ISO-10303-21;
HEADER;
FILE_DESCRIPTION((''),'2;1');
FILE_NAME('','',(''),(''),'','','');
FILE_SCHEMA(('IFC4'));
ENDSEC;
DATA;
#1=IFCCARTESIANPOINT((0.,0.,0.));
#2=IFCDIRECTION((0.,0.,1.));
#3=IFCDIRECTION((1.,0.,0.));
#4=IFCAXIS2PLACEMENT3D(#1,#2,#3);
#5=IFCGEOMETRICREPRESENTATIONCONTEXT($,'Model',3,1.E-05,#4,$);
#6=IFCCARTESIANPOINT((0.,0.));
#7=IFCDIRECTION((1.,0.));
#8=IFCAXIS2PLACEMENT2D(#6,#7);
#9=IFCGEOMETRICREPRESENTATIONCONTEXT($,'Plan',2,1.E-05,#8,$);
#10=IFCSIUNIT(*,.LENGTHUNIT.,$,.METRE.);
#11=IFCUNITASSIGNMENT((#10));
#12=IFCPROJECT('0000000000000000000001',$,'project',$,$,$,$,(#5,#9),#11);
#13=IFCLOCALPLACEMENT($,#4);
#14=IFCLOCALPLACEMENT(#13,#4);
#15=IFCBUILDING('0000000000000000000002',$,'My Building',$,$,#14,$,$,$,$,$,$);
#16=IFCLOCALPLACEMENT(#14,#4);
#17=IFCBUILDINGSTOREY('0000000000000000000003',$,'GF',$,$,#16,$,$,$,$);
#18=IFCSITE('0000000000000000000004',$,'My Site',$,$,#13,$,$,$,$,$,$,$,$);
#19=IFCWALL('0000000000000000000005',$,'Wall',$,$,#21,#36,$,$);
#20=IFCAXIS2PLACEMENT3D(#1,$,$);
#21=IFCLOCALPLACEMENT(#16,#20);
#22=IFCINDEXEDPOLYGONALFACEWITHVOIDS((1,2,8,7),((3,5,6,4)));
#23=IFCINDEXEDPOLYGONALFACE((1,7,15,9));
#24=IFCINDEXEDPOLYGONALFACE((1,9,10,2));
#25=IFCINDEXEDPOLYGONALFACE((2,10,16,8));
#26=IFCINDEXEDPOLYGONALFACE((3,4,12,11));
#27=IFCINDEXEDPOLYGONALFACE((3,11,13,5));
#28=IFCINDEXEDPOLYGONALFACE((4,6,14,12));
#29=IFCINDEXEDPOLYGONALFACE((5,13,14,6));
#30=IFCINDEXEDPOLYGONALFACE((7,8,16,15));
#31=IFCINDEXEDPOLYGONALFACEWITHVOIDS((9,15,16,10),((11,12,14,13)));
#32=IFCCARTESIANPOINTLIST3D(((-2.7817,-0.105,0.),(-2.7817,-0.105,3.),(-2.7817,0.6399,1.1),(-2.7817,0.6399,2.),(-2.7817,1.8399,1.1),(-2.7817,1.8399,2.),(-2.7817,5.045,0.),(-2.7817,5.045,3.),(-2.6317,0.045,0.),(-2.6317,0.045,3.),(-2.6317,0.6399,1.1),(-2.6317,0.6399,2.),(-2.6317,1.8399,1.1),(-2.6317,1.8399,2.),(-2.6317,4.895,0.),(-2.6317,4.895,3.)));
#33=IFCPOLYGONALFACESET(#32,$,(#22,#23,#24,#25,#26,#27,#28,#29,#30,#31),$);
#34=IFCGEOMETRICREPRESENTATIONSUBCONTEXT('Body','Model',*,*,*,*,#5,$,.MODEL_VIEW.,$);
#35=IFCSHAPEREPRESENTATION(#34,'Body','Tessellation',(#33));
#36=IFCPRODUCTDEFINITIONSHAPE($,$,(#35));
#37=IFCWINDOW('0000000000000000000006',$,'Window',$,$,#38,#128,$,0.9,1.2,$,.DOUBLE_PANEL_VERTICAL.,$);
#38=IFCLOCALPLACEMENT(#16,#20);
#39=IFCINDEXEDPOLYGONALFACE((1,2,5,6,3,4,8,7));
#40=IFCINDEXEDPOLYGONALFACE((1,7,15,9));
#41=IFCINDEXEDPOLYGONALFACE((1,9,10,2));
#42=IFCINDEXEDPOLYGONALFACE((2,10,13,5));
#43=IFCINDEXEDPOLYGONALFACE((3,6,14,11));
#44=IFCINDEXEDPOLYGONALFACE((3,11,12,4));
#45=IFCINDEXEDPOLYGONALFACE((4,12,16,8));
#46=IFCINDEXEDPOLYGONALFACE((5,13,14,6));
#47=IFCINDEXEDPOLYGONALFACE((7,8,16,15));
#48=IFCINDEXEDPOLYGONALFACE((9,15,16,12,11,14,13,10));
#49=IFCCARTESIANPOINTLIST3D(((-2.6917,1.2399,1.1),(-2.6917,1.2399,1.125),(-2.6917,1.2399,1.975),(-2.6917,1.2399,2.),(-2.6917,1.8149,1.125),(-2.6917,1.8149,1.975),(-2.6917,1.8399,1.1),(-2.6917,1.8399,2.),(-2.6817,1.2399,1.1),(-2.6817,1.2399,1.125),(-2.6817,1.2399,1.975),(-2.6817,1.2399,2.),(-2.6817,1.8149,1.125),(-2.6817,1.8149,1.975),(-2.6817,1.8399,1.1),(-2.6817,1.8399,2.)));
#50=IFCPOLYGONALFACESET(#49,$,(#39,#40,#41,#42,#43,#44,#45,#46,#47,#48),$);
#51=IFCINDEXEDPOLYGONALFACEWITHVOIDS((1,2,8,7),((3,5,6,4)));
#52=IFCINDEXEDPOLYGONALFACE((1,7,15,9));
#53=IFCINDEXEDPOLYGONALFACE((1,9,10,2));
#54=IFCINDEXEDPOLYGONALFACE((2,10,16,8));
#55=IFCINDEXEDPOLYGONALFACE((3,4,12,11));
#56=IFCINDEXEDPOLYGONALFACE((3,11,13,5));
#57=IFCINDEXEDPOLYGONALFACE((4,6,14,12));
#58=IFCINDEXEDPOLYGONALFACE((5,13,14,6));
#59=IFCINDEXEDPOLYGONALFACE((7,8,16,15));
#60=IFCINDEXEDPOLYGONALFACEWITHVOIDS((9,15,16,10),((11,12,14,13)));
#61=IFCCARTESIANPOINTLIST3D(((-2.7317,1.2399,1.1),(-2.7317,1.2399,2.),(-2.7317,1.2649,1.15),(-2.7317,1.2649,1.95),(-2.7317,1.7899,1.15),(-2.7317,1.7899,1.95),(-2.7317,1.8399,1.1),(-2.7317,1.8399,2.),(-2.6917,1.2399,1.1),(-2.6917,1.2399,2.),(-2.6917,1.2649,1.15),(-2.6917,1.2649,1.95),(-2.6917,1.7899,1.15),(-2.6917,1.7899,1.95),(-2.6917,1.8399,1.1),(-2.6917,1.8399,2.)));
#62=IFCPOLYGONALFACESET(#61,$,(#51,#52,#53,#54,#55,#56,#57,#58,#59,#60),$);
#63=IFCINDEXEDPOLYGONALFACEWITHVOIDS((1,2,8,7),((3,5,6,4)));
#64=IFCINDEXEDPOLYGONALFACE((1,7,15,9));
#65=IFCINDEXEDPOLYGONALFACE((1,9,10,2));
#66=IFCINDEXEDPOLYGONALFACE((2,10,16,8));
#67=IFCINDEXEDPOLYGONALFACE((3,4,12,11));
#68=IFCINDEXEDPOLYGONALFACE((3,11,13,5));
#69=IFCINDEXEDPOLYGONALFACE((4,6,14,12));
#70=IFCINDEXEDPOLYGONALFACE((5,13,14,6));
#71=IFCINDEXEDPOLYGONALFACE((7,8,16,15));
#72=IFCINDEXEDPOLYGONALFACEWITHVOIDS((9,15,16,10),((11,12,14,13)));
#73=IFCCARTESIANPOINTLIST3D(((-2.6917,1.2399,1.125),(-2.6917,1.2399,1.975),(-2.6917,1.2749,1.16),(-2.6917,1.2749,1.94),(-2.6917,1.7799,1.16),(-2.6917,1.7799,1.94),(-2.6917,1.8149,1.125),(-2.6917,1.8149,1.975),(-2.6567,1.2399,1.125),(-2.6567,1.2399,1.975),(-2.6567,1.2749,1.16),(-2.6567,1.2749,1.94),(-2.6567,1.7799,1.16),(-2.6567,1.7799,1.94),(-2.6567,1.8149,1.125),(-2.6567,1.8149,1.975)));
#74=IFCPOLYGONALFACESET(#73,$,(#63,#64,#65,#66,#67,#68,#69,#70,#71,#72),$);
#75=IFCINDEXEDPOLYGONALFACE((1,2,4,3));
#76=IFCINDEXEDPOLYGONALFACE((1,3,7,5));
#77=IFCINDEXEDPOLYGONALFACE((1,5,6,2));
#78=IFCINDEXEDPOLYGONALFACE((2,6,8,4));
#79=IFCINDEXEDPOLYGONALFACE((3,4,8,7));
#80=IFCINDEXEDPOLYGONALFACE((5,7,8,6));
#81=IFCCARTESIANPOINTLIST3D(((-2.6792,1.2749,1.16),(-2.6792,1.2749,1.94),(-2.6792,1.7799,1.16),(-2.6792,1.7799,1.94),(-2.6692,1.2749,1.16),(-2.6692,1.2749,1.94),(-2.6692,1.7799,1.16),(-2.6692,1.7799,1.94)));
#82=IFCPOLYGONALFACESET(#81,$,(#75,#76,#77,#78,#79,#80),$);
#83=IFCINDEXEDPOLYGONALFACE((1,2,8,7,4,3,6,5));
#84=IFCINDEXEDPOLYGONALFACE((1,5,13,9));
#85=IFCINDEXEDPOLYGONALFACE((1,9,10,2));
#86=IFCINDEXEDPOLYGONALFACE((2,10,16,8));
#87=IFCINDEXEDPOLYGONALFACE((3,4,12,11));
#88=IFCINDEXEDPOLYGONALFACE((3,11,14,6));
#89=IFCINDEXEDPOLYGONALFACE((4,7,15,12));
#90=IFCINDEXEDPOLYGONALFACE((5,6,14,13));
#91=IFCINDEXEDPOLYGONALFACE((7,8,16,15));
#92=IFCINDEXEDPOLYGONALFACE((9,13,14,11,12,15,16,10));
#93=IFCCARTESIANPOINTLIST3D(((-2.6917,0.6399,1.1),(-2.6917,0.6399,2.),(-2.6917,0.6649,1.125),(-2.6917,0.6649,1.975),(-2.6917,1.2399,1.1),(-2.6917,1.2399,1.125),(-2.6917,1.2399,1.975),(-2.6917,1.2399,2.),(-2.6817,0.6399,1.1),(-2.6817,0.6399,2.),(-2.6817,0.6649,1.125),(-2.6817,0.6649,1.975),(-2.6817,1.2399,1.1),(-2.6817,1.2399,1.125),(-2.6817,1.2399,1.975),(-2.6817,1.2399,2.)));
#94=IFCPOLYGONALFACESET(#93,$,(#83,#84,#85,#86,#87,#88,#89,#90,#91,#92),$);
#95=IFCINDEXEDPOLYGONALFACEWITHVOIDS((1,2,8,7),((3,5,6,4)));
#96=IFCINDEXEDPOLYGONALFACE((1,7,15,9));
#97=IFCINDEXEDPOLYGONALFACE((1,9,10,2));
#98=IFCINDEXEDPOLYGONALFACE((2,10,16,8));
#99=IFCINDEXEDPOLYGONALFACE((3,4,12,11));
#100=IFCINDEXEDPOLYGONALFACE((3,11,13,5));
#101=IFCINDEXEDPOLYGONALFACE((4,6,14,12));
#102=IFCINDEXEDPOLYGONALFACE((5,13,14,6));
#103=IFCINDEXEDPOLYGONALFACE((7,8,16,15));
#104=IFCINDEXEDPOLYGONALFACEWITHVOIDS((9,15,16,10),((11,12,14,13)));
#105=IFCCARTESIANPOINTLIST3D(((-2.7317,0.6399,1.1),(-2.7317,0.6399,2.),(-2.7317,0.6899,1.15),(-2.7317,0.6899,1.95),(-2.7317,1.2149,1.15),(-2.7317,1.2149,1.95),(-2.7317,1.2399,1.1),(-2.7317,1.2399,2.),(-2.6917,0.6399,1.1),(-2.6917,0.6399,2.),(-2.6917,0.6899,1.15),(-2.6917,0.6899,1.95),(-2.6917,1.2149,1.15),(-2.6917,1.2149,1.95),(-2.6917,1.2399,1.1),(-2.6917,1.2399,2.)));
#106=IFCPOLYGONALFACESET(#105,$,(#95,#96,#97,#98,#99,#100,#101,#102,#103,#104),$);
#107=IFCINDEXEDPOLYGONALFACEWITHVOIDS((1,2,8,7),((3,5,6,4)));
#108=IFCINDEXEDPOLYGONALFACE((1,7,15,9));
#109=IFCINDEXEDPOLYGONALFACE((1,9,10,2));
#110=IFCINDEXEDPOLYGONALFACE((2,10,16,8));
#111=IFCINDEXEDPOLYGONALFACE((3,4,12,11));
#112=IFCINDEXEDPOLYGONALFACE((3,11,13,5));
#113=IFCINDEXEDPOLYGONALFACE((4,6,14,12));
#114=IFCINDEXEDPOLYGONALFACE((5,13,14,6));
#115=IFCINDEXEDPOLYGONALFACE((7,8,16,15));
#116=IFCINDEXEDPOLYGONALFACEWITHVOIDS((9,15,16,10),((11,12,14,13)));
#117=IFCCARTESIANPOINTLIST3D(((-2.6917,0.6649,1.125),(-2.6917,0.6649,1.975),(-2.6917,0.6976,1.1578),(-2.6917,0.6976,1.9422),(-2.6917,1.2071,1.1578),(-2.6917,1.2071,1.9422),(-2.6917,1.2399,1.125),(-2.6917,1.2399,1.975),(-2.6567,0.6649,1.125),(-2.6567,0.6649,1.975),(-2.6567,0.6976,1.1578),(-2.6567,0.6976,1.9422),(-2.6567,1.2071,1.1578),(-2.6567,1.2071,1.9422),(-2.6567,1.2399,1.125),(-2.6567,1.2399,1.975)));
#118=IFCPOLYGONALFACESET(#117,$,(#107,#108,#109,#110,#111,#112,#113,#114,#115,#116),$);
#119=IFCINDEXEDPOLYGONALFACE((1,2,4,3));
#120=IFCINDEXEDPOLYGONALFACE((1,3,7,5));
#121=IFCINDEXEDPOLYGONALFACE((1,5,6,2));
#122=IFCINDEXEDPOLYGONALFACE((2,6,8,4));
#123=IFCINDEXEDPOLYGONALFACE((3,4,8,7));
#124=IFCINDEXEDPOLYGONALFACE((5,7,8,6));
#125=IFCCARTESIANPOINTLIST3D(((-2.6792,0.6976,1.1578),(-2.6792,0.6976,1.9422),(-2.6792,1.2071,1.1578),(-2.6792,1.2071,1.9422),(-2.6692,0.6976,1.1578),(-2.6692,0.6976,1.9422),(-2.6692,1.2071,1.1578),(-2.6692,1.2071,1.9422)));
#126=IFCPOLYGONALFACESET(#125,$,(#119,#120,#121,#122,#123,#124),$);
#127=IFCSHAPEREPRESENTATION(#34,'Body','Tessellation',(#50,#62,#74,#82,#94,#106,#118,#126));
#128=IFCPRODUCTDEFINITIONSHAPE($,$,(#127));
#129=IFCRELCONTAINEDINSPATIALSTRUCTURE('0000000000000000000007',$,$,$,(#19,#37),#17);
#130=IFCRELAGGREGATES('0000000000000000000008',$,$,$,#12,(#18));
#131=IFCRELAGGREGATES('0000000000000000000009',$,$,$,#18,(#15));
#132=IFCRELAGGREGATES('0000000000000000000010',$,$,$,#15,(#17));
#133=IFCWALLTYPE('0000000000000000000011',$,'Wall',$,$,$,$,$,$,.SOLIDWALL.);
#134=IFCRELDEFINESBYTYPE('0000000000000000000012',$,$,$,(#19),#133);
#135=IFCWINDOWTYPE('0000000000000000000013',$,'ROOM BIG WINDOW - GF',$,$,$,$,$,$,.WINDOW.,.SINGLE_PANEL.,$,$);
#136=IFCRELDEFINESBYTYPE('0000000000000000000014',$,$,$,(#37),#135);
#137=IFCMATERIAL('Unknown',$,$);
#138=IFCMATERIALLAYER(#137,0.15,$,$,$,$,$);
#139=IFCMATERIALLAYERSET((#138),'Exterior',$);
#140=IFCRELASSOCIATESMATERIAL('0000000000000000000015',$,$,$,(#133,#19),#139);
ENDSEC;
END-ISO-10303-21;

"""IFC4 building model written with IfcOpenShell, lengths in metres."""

from ifc_helpers import new_model, entity, si_unit, frame, origin_with_axes, origin_2d_with_axis, place, context, subcontext, project, spatial, line, indexed_curve, outline, extrude, shape, source, transform, mapped, material, layer, layer_set, layer_usage, type_object, type_shapes, element, fill, save


model = new_model("IFC4")

# Units and contexts
model_context = context("Model", 3, precision=1e-05, world=origin_with_axes())
plan_context = context("Plan", 2, precision=1e-05, world=origin_2d_with_axis())
body_context_1 = subcontext(model_context, "Body", "Model", "MODEL_VIEW")
body_context_2 = subcontext(plan_context, "Body", "Plan", "PLAN_VIEW")
ifc_project = project(units=[si_unit("LENGTHUNIT", "METRE")], contexts=[model_context, plan_context])

# Site, building, storey
site_placement = place(None, origin_with_axes())
site = spatial("IfcSite", under=ifc_project, at=site_placement, Name="My Site")
building_placement = place(site_placement, origin_with_axes())
building = spatial("IfcBuilding", under=site, at=building_placement, Name="My Building")
storey_placement = place(building_placement, origin_with_axes())
storey = spatial("IfcBuildingStorey", under=building, at=storey_placement, Name="GF")

# Shared definitions
ifc_material = material(Name="Unknown")
ifc_layer_1 = layer(ifc_material, 0.15)
ifc_layer_set_1 = layer_set([ifc_layer_1], Name="Exterior")
wall_type_1 = type_object("IfcWallType", Name="Wall", PredefinedType="SOLIDWALL", material=ifc_layer_set_1)

# Wall, opening, window
ifc_layer_usage_1 = layer_usage(ifc_layer_set_1, "AXIS2", "POSITIVE", 0.0)
wall_1_placement = place(storey_placement, frame((-2.7817, 5.045, 0.0), z_axis=(0.0, 0.0, 1.0), x_axis=(0.0, -1.0, 0.0)))
wall_1 = element("IfcWall", 1, at=wall_1_placement, inside=storey, type_object=wall_type_1, material=ifc_layer_usage_1, Name="Wall", context=body_context_1, shape_type="SweptSolid", body=[
    extrude(outline(indexed_curve([(0.0, 0.0), (0.15, 0.15), (5.0, 0.15), (5.15, 0.0)], segments=[line(1, 2, 3, 4, 1)])), origin_with_axes(), (0.0, 0.0, 1.0), 3.0),
])
shared_shape_1 = source(origin_with_axes(), body_context_1, "Body", "SweptSolid", [
    extrude(outline(indexed_curve([(0.0, 0.0), (1.2, 0.0), (1.2, 0.9), (0.0, 0.9)], segments=[line(1, 2, 3, 4, 1)])), frame((0.0, -0.6, 0.0), z_axis=(0.0, -1.0, 0.0), x_axis=(1.0, 0.0, 0.0)), (0.0, 0.0, -1.0), 1.2),
])
opening_1_placement = place(wall_1_placement, frame((3.2051, 0.0, 1.1), z_axis=(0.0, 0.0, 1.0), x_axis=(1.0, 0.0, 0.0)))
opening_1 = element("IfcOpeningElement", 2, at=opening_1_placement, cuts=wall_1, PredefinedType="OPENING", context=body_context_1, shape_type="MappedRepresentation", body=[
    mapped(shared_shape_1, transform((0.0, 0.0, 0.0), x_axis=(1.0, 0.0, 0.0), y_axis=(0.0, 1.0, 0.0), z_axis=(0.0, 0.0, 1.0), scale=1.0)),
])
window_type_1 = type_object("IfcWindowType", Name="ROOM BIG WINDOW - GF", PartitioningType="SINGLE_PANEL", PredefinedType="WINDOW")
shared_shape_2 = source(origin_with_axes(), body_context_1, "Body", "SweptSolid", [
    extrude(outline(indexed_curve([(0.6, 0.0), (0.0, 0.0), (0.0, 0.9), (0.6, 0.9), (0.6, 0.875), (0.025, 0.875), (0.025, 0.025), (0.6, 0.025)], segments=[line(1, 2, 3, 4, 5, 6, 7, 8, 1)])), frame((0.0, 0.09, 0.0), z_axis=(0.0, -1.0, 0.0), x_axis=(1.0, 0.0, 0.0)), (0.0, 0.0, -1.0), 0.01),
    extrude(outline(indexed_curve([(0.0, 0.0), (0.6, 0.0), (0.6, 0.9), (0.0, 0.9)], segments=[line(1, 2, 3, 4, 1)]), holes=[indexed_curve([(0.05, 0.05), (0.575, 0.05), (0.575, 0.85), (0.05, 0.85)], segments=[line(1, 2, 3, 4, 1)])]), frame((0.0, 0.05, 0.0), z_axis=(0.0, -1.0, 0.0), x_axis=(1.0, 0.0, 0.0)), (0.0, 0.0, -1.0), 0.04),
    extrude(outline(indexed_curve([(0.0, 0.0), (0.575, 0.0), (0.575, 0.85), (0.0, 0.85)], segments=[line(1, 2, 3, 4, 1)]), holes=[indexed_curve([(0.035, 0.035), (0.54, 0.035), (0.54, 0.815), (0.035, 0.815)], segments=[line(1, 2, 3, 4, 1)])]), frame((0.025, 0.09, 0.025), z_axis=(0.0, -1.0, 0.0), x_axis=(1.0, 0.0, 0.0)), (0.0, 0.0, -1.0), 0.035),
    extrude(outline(indexed_curve([(0.035, 0.035), (0.54, 0.035), (0.54, 0.815), (0.035, 0.815)], segments=[line(1, 2, 3, 4, 1)])), frame((0.025, 0.1025, 0.025), z_axis=(0.0, -1.0, 0.0), x_axis=(1.0, 0.0, 0.0)), (0.0, 0.0, -1.0), 0.01),
    extrude(outline(indexed_curve([(0.0, 0.9), (0.6, 0.9), (0.6, 0.0), (0.0, 0.0), (0.0, 0.025), (0.575, 0.025), (0.575, 0.875), (0.0, 0.875)], segments=[line(1, 2, 3, 4, 5, 6, 7, 8, 1)])), frame((0.6, 0.09, 0.0), z_axis=(0.0, -1.0, 0.0), x_axis=(1.0, 0.0, 0.0)), (0.0, 0.0, -1.0), 0.01),
    extrude(outline(indexed_curve([(0.0, 0.0), (0.6, 0.0), (0.6, 0.9), (0.0, 0.9)], segments=[line(1, 2, 3, 4, 1)]), holes=[indexed_curve([(0.025, 0.05), (0.55, 0.05), (0.55, 0.85), (0.025, 0.85)], segments=[line(1, 2, 3, 4, 1)])]), frame((0.6, 0.05, 0.0), z_axis=(0.0, -1.0, 0.0), x_axis=(1.0, 0.0, 0.0)), (0.0, 0.0, -1.0), 0.04),
    extrude(outline(indexed_curve([(0.0, 0.0), (0.575, 0.0), (0.575, 0.85), (0.0, 0.85)], segments=[line(1, 2, 3, 4, 1)]), holes=[indexed_curve([(0.0328, 0.0328), (0.5422, 0.0328), (0.5422, 0.8172), (0.0328, 0.8172)], segments=[line(1, 2, 3, 4, 1)])]), frame((0.6, 0.09, 0.025), z_axis=(0.0, -1.0, 0.0), x_axis=(1.0, 0.0, 0.0)), (0.0, 0.0, -1.0), 0.035),
    extrude(outline(indexed_curve([(0.0328, 0.0328), (0.5422, 0.0328), (0.5422, 0.8172), (0.0328, 0.8172)], segments=[line(1, 2, 3, 4, 1)])), frame((0.6, 0.1025, 0.025), z_axis=(0.0, -1.0, 0.0), x_axis=(1.0, 0.0, 0.0)), (0.0, 0.0, -1.0), 0.01),
])
shared_shape_3 = source(origin_with_axes(), body_context_2, "Body", "Curve2D", [
    entity("IfcIndexedPolyCurve", entity("IfcCartesianPointList2D", [[0.05, 0.05], [0.575, 0.05]])),
    entity("IfcIndexedPolyCurve", entity("IfcCartesianPointList2D", [[0.0, 0.1], [0.025, 0.1], [0.025, 0.09], [0.05, 0.09], [0.05, 0.05], [0.0, 0.05]]), [entity("IfcLineIndex", [1, 2, 3, 4, 5, 6, 1])]),
    entity("IfcIndexedPolyCurve", entity("IfcCartesianPointList2D", [[0.6, 0.1], [0.6, 0.1], [0.6, 0.09], [0.575, 0.09], [0.575, 0.05], [0.6, 0.05]])),
    entity("IfcIndexedPolyCurve", entity("IfcCartesianPointList2D", [[0.025, 0.09], [0.06, 0.09], [0.06, 0.125], [0.025, 0.125]]), [entity("IfcLineIndex", [1, 2, 3, 4, 1])]),
    entity("IfcIndexedPolyCurve", entity("IfcCartesianPointList2D", [[0.6, 0.09], [0.565, 0.09], [0.565, 0.125], [0.6, 0.125]]), [entity("IfcLineIndex", [1, 2, 3, 4, 1])]),
    entity("IfcIndexedPolyCurve", entity("IfcCartesianPointList2D", [[0.06, 0.09], [0.565, 0.09]])),
    entity("IfcIndexedPolyCurve", entity("IfcCartesianPointList2D", [[0.06, 0.125], [0.565, 0.125]])),
    entity("IfcIndexedPolyCurve", entity("IfcCartesianPointList2D", [[0.06, 0.1075], [0.565, 0.1075]])),
    entity("IfcIndexedPolyCurve", entity("IfcCartesianPointList2D", [[0.625, 0.05], [1.15, 0.05]])),
    entity("IfcIndexedPolyCurve", entity("IfcCartesianPointList2D", [[0.6, 0.1], [0.6, 0.1], [0.6, 0.09], [0.625, 0.09], [0.625, 0.05], [0.6, 0.05]])),
    entity("IfcIndexedPolyCurve", entity("IfcCartesianPointList2D", [[1.2, 0.1], [1.175, 0.1], [1.175, 0.09], [1.15, 0.09], [1.15, 0.05], [1.2, 0.05]]), [entity("IfcLineIndex", [1, 2, 3, 4, 5, 6, 1])]),
    entity("IfcIndexedPolyCurve", entity("IfcCartesianPointList2D", [[0.6, 0.09], [0.6328, 0.09], [0.6328, 0.125], [0.6, 0.125]]), [entity("IfcLineIndex", [1, 2, 3, 4, 1])]),
    entity("IfcIndexedPolyCurve", entity("IfcCartesianPointList2D", [[1.175, 0.09], [1.1422, 0.09], [1.1422, 0.125], [1.175, 0.125]]), [entity("IfcLineIndex", [1, 2, 3, 4, 1])]),
    entity("IfcIndexedPolyCurve", entity("IfcCartesianPointList2D", [[0.6328, 0.09], [1.1422, 0.09]])),
    entity("IfcIndexedPolyCurve", entity("IfcCartesianPointList2D", [[0.6328, 0.125], [1.1422, 0.125]])),
    entity("IfcIndexedPolyCurve", entity("IfcCartesianPointList2D", [[0.6328, 0.1075], [1.1422, 0.1075]])),
])
type_shapes(window_type_1, [shared_shape_2, shared_shape_3])
window_1_placement = place(opening_1_placement, frame((0.0, 0.0, 0.0), z_axis=(0.0, 0.0, 1.0), x_axis=(1.0, 0.0, 0.0)))
window_1 = element("IfcWindow", 3, at=window_1_placement, inside=storey, type_object=window_type_1, Name="Window", OverallHeight=0.9, OverallWidth=1.2, PartitioningType="DOUBLE_PANEL_VERTICAL", shapes=[
    shape(body_context_1, "Body", "MappedRepresentation", [mapped(shared_shape_2, transform((0.0, 0.0, 0.0), x_axis=(1.0, 0.0, 0.0), y_axis=(0.0, 1.0, 0.0), z_axis=(0.0, 0.0, 1.0), scale=1.0))]),
    shape(body_context_2, "Body", "MappedRepresentation", [mapped(shared_shape_3, transform((0.0, 0.0, 0.0), x_axis=(1.0, 0.0, 0.0), y_axis=(0.0, 1.0, 0.0), z_axis=(0.0, 0.0, 1.0), scale=1.0))]),
])
fill(opening_1, window_1)

save(model, "model.ifc")
